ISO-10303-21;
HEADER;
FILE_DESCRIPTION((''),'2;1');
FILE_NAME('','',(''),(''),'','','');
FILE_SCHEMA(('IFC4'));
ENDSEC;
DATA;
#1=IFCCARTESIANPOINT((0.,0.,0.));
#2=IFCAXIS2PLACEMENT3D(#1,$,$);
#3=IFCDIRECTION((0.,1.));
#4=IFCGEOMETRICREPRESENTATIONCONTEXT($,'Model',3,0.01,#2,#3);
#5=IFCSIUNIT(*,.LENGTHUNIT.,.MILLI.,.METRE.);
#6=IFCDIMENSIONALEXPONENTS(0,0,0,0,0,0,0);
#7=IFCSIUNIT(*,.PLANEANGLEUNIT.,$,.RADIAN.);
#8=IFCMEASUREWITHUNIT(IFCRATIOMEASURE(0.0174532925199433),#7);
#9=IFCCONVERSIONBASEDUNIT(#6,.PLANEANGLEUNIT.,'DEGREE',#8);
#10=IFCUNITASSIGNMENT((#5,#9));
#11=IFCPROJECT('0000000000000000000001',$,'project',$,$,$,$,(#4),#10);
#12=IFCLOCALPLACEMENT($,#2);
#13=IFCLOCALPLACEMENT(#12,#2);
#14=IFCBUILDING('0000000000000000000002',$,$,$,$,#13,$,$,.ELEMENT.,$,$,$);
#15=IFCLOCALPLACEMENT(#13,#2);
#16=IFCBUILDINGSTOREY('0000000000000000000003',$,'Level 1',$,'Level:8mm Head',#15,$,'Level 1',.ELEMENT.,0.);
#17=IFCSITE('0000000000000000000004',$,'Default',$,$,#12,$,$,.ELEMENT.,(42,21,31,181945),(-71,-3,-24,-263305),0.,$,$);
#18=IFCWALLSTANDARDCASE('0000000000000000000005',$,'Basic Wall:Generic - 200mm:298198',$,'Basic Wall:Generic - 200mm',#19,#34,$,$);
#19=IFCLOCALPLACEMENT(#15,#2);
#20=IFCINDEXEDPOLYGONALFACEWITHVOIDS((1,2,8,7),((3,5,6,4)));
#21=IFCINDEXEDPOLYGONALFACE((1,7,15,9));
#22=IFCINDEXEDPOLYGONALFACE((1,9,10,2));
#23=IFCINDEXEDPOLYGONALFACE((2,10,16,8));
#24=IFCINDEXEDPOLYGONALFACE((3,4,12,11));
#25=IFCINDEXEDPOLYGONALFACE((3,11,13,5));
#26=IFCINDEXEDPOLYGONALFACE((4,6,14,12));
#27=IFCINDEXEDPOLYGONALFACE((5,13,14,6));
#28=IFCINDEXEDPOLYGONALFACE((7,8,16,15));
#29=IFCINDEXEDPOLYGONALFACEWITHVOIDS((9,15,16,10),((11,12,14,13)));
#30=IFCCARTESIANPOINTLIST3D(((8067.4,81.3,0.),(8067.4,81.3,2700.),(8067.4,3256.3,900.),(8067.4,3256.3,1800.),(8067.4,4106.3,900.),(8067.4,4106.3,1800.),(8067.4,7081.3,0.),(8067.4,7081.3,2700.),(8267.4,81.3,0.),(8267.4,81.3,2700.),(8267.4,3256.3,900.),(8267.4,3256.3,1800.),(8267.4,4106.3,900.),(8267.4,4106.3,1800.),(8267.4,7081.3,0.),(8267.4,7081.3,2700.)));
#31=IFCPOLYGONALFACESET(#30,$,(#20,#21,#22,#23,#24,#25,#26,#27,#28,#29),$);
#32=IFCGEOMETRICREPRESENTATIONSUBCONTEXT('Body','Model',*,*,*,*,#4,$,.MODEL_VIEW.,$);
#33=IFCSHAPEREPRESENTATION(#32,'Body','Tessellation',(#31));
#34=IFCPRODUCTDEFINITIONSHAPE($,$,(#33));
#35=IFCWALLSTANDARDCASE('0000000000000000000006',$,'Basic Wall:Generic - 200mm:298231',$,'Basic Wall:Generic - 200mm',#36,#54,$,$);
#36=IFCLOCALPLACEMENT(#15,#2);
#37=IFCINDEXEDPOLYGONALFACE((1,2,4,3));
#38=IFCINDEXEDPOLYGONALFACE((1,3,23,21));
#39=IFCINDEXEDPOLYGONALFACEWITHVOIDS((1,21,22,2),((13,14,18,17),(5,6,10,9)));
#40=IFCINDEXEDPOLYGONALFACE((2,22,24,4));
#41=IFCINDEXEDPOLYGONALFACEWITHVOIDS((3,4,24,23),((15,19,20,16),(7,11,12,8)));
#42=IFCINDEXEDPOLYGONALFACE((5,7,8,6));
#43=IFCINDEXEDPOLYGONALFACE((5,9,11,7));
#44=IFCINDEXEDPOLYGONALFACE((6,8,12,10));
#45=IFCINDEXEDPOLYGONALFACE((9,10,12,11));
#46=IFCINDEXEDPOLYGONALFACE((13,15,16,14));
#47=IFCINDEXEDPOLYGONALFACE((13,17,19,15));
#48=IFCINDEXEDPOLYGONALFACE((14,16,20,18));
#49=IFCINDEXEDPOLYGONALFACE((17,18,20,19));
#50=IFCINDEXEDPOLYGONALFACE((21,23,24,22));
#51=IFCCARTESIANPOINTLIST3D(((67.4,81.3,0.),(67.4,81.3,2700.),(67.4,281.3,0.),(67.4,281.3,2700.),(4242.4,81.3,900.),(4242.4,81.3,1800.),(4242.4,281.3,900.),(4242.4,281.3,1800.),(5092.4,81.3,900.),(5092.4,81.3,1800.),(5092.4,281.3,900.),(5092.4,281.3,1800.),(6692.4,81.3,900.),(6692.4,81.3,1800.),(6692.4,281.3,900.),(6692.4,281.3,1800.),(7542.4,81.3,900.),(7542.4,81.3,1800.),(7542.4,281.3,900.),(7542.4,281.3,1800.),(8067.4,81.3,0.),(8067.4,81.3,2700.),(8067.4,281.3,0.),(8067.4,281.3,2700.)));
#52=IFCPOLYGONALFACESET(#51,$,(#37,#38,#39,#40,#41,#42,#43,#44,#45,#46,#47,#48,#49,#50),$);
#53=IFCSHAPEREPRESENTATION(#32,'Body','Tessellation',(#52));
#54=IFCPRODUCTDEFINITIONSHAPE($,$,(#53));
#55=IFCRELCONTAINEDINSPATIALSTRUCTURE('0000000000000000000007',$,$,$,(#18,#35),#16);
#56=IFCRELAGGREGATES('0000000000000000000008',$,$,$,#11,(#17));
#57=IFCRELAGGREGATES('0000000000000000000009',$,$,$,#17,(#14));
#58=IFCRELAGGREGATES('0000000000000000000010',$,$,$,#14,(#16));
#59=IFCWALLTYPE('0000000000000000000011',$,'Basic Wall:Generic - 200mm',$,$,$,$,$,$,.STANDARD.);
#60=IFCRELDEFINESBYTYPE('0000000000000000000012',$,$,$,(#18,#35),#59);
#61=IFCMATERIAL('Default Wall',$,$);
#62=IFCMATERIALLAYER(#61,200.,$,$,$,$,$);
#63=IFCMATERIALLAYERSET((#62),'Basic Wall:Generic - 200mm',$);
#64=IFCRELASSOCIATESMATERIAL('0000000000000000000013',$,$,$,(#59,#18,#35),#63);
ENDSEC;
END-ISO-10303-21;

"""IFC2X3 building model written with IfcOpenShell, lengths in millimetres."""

from ifc_helpers import new_model, entity, si_unit, converted_unit, direction, frame, frame_2d, origin, place, context, subcontext, project, spatial, rectangle, extrude, material, layer, layer_set, layer_usage, type_object, element, save


model = new_model("IFC2X3")

# Units and contexts
model_context = context("Model", 3, precision=0.01, world=origin(), true_north=direction((0.0, 1.0)))
body_context = subcontext(model_context, "Body", "Model", "MODEL_VIEW")
ifc_project = project(units=[si_unit("LENGTHUNIT", "METRE", prefix="MILLI"), converted_unit("PLANEANGLEUNIT", "DEGREE", entity("IfcRatioMeasure", 0.0174532925199433), si_unit("PLANEANGLEUNIT", "RADIAN"), dimensions=[0, 0, 0, 0, 0, 0, 0])], contexts=[model_context])

# Site, building, storey
site_placement = place(None, origin())
site = spatial("IfcSite", under=ifc_project, at=site_placement, Name="Default", CompositionType="ELEMENT", RefLatitude=(42, 21, 31, 181945), RefLongitude=(-71, -3, -24, -263305), RefElevation=0.0)
building_placement = place(site_placement, origin())
building = spatial("IfcBuilding", under=site, at=building_placement, CompositionType="ELEMENT")
storey_placement = place(building_placement, origin())
storey = spatial("IfcBuildingStorey", under=building, at=storey_placement, Name="Level 1", ObjectType="Level:8mm Head", LongName="Level 1", CompositionType="ELEMENT", Elevation=0.0)

# Wall, opening
ifc_material_1 = material(Name="Default Wall")
ifc_layer = layer(ifc_material_1, 200.0)
ifc_layer_set = layer_set([ifc_layer], Name="Basic Wall:Generic - 200mm")
ifc_layer_usage_1 = layer_usage(ifc_layer_set, "AXIS2", "NEGATIVE", 100.0)
wall_type = type_object("IfcWallType", Name="Basic Wall:Generic - 200mm", PredefinedType="STANDARD", material=ifc_layer_set)
wall_1_placement = place(storey_placement, frame((8167.4, 7081.3, 0.0), z_axis=(0.0, 0.0, 1.0), x_axis=(0.0, -1.0, 0.0)))
wall_1 = element("IfcWallStandardCase", 1, at=wall_1_placement, inside=storey, type_object=wall_type, material=ifc_layer_usage_1, Name="Basic Wall:Generic - 200mm:298198", ObjectType="Basic Wall:Generic - 200mm", context=body_context, shape_type="SweptSolid", body=[
    extrude(rectangle(XDim=7000.0, YDim=200.0, at=frame_2d((3500.0, 0.0), x_axis=(-1.0, 0.0))), origin(), (0.0, 0.0, 1.0), 2700.0),
])
opening_1_placement = place(wall_1_placement, frame((3825.0, 100.0, 900.0)))
element("IfcOpeningElement", 2, at=opening_1_placement, cuts=wall_1, ObjectType="Opening", context=body_context, shape_type="SweptSolid", body=[
    extrude(rectangle(XDim=900.0, YDim=850.0, at=frame_2d((450.0, 425.0), x_axis=(-1.0, 0.0))), frame((0.0, 0.0, 0.0), z_axis=(0.0, -1.0, 0.0), x_axis=(0.0, 0.0, 1.0)), (0.0, 0.0, 1.0), 200.0),
])

# Wall, openings
ifc_layer_usage_2 = layer_usage(ifc_layer_set, "AXIS2", "NEGATIVE", 100.0)
wall_2_placement = place(storey_placement, frame((8067.4, 181.3, 0.0), z_axis=(0.0, 0.0, 1.0), x_axis=(-1.0, 0.0, 0.0)))
wall_2 = element("IfcWallStandardCase", 3, at=wall_2_placement, inside=storey, type_object=wall_type, material=ifc_layer_usage_2, Name="Basic Wall:Generic - 200mm:298231", ObjectType="Basic Wall:Generic - 200mm", context=body_context, shape_type="SweptSolid", body=[
    extrude(rectangle(XDim=8000.0, YDim=200.0, at=frame_2d((4000.0, 0.0), x_axis=(-1.0, 0.0))), origin(), (0.0, 0.0, 1.0), 2700.0),
])
opening_2_placement = place(wall_2_placement, frame((1375.0, 100.0, 900.0)))
element("IfcOpeningElement", 4, at=opening_2_placement, cuts=wall_2, ObjectType="Opening", context=body_context, shape_type="SweptSolid", body=[
    extrude(rectangle(XDim=900.0, YDim=850.0, at=frame_2d((450.0, 425.0), x_axis=(-1.0, 0.0))), frame((0.0, 0.0, 0.0), z_axis=(0.0, -1.0, 0.0), x_axis=(0.0, 0.0, 1.0)), (0.0, 0.0, 1.0), 200.0),
])
opening_3_placement = place(wall_2_placement, frame((3825.0, 100.0, 900.0)))
element("IfcOpeningElement", 5, at=opening_3_placement, cuts=wall_2, ObjectType="Opening", context=body_context, shape_type="SweptSolid", body=[
    extrude(rectangle(XDim=900.0, YDim=850.0, at=frame_2d((450.0, 425.0), x_axis=(-1.0, 0.0))), frame((0.0, 0.0, 0.0), z_axis=(0.0, -1.0, 0.0), x_axis=(0.0, 0.0, 1.0)), (0.0, 0.0, 1.0), 200.0),
])

save(model, "model.ifc")
